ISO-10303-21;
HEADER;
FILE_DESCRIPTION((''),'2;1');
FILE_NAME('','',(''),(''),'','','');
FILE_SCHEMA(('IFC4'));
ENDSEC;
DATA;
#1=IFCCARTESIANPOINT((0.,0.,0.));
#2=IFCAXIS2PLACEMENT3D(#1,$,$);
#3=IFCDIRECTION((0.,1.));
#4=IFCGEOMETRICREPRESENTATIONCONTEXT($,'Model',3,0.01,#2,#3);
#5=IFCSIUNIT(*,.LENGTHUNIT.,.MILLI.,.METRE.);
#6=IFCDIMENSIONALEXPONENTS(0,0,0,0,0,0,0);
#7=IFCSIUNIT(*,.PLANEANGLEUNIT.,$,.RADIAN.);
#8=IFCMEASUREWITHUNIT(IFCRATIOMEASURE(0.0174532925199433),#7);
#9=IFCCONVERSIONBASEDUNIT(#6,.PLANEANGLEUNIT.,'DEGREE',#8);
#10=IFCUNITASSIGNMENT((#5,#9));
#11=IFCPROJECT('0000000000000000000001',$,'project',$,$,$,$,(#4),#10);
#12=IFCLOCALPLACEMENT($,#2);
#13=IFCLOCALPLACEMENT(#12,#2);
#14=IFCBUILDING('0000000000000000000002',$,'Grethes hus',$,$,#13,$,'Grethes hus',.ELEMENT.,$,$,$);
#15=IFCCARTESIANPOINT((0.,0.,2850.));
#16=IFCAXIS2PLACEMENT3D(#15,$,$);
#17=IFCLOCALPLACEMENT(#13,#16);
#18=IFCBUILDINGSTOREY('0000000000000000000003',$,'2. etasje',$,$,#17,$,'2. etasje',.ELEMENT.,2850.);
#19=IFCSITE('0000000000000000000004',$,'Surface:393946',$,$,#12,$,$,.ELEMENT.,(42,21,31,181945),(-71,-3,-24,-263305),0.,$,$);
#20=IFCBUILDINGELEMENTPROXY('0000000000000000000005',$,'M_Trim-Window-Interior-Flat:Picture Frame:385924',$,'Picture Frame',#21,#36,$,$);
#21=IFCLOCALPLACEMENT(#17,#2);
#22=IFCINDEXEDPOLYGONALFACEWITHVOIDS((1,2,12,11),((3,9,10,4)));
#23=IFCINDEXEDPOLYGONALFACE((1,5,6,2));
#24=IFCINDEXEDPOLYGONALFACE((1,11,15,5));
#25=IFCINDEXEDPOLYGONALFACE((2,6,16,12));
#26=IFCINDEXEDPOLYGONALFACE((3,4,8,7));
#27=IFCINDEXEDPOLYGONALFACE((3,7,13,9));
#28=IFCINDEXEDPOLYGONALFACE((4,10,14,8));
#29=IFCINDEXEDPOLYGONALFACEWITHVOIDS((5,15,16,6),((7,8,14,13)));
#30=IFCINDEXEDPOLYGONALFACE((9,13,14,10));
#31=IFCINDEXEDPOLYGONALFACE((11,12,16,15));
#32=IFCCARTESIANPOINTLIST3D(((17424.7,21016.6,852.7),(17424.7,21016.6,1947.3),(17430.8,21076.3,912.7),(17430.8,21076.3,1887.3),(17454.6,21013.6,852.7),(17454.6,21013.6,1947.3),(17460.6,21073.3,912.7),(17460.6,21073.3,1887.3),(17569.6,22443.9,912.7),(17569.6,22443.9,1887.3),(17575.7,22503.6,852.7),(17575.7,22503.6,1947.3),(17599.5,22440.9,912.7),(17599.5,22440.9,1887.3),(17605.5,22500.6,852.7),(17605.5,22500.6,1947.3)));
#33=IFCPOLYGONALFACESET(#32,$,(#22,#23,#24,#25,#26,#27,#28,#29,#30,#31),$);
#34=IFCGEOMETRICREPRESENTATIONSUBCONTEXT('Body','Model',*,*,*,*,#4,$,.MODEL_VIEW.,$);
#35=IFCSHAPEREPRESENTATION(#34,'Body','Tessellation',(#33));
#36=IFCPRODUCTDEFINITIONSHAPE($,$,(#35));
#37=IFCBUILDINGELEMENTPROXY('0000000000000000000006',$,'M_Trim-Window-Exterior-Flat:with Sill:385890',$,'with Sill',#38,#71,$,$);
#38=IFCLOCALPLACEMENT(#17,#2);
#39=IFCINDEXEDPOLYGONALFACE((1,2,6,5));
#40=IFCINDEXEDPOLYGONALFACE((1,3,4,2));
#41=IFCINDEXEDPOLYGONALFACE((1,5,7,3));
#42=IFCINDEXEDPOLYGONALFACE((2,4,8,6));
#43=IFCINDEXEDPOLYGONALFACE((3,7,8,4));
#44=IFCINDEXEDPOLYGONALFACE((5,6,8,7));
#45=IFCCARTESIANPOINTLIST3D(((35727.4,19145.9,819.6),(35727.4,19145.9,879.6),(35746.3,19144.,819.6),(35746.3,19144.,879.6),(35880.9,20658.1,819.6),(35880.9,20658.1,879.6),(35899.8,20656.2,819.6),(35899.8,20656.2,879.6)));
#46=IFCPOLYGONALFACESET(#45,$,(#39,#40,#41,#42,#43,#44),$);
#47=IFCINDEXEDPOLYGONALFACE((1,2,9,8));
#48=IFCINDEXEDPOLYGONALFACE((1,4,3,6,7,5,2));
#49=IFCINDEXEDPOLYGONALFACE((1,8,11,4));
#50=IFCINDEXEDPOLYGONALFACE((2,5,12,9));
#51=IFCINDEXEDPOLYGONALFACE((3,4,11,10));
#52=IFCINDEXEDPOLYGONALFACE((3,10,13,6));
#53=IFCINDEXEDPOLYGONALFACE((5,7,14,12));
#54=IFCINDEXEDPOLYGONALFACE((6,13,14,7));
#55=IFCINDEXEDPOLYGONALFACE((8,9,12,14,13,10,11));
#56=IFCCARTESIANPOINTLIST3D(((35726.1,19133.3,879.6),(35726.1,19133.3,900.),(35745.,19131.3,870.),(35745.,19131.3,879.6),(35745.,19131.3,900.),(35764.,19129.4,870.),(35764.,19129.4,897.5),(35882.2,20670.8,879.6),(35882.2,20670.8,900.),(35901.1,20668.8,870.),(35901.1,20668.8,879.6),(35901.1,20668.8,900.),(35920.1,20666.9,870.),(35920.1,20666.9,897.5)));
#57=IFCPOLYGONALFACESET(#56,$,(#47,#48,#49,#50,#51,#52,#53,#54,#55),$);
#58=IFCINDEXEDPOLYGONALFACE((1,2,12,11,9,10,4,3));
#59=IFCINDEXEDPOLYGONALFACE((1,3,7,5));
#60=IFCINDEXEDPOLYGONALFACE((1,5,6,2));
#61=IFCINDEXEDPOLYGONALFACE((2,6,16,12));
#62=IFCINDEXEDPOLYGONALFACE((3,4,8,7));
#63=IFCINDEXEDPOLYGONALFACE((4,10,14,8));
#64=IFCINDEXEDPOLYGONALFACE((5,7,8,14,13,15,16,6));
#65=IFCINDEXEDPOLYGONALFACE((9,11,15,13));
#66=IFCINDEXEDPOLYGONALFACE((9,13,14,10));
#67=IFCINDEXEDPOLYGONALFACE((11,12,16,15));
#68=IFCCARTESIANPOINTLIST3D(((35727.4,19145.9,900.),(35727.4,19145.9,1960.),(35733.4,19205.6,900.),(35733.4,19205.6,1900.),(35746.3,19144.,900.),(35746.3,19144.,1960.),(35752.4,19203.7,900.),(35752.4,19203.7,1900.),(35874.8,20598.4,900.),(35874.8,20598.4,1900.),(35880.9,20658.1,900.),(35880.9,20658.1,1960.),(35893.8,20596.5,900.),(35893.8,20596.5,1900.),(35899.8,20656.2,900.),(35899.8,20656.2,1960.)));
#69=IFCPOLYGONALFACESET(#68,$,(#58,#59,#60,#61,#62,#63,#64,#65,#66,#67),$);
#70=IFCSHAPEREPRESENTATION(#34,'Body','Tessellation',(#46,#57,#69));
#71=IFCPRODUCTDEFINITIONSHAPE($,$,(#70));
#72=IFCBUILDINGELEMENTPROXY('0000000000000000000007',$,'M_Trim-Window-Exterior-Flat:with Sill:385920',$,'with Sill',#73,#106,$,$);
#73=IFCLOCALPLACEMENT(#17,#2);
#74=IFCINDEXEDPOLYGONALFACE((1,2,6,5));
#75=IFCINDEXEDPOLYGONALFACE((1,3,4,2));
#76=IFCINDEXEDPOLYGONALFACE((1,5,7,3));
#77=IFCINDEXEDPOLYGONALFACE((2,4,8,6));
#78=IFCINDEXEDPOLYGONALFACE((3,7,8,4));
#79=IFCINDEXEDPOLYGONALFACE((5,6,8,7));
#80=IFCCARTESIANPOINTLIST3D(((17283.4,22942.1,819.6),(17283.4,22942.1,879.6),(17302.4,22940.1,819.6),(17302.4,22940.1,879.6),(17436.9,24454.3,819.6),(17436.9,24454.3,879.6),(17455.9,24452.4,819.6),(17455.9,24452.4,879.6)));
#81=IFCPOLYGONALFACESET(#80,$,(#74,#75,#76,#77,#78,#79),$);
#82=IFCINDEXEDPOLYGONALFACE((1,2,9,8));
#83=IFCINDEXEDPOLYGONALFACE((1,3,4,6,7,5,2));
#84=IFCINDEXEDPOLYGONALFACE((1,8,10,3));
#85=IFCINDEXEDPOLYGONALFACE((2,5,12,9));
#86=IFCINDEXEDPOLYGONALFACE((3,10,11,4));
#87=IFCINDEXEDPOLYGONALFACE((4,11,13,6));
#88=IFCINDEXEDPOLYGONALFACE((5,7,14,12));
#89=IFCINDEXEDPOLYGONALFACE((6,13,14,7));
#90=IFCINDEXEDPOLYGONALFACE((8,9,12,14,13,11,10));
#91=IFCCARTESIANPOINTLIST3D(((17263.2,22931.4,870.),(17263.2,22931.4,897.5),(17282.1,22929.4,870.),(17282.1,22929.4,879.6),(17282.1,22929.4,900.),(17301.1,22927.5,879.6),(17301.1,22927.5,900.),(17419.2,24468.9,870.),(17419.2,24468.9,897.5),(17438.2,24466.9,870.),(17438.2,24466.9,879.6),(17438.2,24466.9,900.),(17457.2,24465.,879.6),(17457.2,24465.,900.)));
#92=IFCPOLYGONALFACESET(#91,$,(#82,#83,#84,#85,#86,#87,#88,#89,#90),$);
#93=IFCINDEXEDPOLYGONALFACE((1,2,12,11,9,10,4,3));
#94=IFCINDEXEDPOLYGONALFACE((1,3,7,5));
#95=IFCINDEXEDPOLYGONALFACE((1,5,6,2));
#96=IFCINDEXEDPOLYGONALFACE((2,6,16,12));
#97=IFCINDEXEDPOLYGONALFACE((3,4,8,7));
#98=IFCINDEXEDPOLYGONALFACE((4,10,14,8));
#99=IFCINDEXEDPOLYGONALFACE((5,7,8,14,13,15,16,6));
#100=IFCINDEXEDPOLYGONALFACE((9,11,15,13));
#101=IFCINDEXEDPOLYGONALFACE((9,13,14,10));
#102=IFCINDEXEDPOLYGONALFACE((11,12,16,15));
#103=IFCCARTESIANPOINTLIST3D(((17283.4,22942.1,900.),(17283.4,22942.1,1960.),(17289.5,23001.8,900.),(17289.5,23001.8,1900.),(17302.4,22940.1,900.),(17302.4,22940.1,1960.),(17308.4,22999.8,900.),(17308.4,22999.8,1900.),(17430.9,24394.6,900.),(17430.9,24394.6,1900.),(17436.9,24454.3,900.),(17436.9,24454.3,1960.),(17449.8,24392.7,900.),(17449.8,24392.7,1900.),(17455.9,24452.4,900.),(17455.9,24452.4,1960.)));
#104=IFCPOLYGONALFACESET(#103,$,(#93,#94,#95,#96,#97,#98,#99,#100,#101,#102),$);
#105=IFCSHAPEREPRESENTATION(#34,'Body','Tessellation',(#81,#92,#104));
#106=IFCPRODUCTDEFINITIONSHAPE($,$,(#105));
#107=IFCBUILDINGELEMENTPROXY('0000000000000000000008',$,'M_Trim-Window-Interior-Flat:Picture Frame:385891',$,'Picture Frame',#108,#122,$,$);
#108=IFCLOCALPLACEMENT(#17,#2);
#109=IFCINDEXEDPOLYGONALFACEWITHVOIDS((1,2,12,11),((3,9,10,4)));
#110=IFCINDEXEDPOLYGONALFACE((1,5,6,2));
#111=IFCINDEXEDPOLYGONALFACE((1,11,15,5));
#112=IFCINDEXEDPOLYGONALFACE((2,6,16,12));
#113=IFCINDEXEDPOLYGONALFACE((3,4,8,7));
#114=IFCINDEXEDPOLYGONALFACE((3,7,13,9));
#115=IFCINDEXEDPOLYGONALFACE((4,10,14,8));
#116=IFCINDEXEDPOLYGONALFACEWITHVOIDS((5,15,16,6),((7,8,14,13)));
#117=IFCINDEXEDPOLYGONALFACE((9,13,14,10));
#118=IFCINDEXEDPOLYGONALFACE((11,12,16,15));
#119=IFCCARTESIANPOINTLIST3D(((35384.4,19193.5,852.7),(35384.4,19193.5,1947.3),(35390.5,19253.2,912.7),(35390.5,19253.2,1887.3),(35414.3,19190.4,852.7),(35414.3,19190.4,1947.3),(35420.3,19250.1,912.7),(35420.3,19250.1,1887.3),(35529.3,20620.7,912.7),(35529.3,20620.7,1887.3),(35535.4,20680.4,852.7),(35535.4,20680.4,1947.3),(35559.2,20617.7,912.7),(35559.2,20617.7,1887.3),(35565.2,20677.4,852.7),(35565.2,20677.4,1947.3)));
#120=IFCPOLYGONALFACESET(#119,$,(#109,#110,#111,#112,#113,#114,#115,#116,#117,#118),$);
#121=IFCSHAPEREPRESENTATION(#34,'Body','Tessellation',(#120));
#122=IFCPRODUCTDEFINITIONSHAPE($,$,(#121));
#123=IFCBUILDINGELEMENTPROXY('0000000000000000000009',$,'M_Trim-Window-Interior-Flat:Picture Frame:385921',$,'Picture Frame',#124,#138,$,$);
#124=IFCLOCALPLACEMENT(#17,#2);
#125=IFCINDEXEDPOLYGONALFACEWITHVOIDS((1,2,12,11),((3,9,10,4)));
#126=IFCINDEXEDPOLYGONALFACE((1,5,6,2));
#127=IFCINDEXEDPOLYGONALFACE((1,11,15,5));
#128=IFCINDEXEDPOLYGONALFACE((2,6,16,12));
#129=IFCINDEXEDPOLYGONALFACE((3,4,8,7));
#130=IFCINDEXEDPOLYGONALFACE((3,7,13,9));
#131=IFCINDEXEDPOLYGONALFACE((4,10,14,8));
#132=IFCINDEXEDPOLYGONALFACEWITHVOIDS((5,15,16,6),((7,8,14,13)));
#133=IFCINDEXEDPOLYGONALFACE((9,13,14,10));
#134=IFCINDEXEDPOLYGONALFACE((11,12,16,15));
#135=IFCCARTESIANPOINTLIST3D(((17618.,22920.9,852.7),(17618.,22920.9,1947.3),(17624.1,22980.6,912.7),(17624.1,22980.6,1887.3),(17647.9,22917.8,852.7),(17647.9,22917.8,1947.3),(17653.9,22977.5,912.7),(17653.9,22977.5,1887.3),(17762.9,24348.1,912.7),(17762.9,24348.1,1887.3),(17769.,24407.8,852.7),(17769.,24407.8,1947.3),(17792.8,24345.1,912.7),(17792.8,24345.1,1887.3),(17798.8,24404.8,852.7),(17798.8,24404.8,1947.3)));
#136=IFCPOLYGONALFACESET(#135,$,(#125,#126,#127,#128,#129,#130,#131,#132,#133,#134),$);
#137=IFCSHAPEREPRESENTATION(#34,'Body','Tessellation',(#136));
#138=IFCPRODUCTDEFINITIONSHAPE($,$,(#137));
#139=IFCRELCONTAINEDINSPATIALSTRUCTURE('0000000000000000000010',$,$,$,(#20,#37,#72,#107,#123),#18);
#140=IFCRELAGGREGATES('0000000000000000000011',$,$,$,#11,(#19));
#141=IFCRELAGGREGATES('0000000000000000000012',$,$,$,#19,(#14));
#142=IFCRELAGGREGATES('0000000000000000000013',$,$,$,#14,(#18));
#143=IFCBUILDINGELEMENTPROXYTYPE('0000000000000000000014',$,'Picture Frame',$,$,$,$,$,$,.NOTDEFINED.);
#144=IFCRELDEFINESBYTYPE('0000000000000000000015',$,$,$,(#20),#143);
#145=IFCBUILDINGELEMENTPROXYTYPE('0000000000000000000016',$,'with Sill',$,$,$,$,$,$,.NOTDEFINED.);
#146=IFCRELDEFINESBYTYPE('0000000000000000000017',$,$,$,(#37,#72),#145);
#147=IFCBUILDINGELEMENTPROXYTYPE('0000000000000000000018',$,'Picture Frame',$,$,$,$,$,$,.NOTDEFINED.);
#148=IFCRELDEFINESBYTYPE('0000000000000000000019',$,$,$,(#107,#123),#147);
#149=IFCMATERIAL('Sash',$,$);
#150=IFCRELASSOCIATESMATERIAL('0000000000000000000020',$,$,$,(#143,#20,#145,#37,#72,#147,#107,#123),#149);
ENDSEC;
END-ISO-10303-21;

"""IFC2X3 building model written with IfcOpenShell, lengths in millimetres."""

from ifc_helpers import new_model, entity, si_unit, converted_unit, direction, frame, frame_2d, origin, place, context, subcontext, project, spatial, polyline, rectangle, outline, extrude, source, transform, mapped, material, type_object, type_shapes, element, save


model = new_model("IFC2X3")

# Units and contexts
model_context = context("Model", 3, precision=0.01, world=origin(), true_north=direction((0.0, 1.0)))
body_context = subcontext(model_context, "Body", "Model", "MODEL_VIEW")
ifc_project = project(units=[si_unit("LENGTHUNIT", "METRE", prefix="MILLI"), converted_unit("PLANEANGLEUNIT", "DEGREE", entity("IfcRatioMeasure", 0.0174532925199433), si_unit("PLANEANGLEUNIT", "RADIAN"), dimensions=[0, 0, 0, 0, 0, 0, 0])], contexts=[model_context])

# Site, building, storey
site_placement = place(None, origin())
site = spatial("IfcSite", under=ifc_project, at=site_placement, Name="Surface:393946", CompositionType="ELEMENT", RefLatitude=(42, 21, 31, 181945), RefLongitude=(-71, -3, -24, -263305), RefElevation=0.0)
building_placement = place(site_placement, origin())
building = spatial("IfcBuilding", under=site, at=building_placement, Name="Grethes hus", LongName="Grethes hus", CompositionType="ELEMENT")
storey_placement = place(building_placement, frame((0.0, 0.0, 2850.0)))
storey = spatial("IfcBuildingStorey", under=building, at=storey_placement, Name="2. etasje", LongName="2. etasje", CompositionType="ELEMENT", Elevation=2850.0)

# Building element proxies
ifc_material_1 = material(Name="Sash")
building_element_proxy_type_1 = type_object("IfcBuildingElementProxyType", Name="Picture Frame", PredefinedType="NOTDEFINED", material=ifc_material_1)
shared_shape_1 = source(origin(), body_context, "Body", "SweptSolid", [
    extrude(outline(polyline([(-747.3, -547.3), (747.3, -547.3), (747.3, 547.3), (-747.3, 547.3), (-747.3, -547.3)]), holes=[polyline([(-687.3, -487.3), (-687.3, 487.3), (687.3, 487.3), (687.3, -487.3), (-687.3, -487.3)])]), frame((0.0, -500.0, 0.0), z_axis=(0.0, 0.0, 1.0), x_axis=(-1.0, 0.0, 0.0)), (0.0, 0.0, 1.0), 30.0),
])
type_shapes(building_element_proxy_type_1, [shared_shape_1])
for number, where, z_axis, x_axis, name in (
    (1, (17500.2, 21760.1, 1900.0), (0.994887, -0.100996, 0.0), (0.100996, 0.994887, 0.0), "M_Trim-Window-Interior-Flat:Picture Frame:385924"),
):
    element("IfcBuildingElementProxy", number, at=place(storey_placement, frame(where, z_axis=z_axis, x_axis=x_axis)), inside=storey, type_object=building_element_proxy_type_1, material=ifc_material_1, Name=name, ObjectType="Picture Frame", context=body_context, shape_type="MappedRepresentation", body=[
        mapped(shared_shape_1, transform((0.0, 0.0, 0.0), scale=1.0)),
    ])
building_element_proxy_type_2 = type_object("IfcBuildingElementProxyType", Name="with Sill", PredefinedType="NOTDEFINED", material=ifc_material_1)
shared_shape_2 = source(origin(), body_context, "Body", "SweptSolid", [
    extrude(rectangle(XDim=60.0, YDim=1520.0, at=frame_2d((0.0, 0.0), x_axis=(1.0, 0.0))), frame((0.0, 1050.4, 0.0), z_axis=(0.0, 0.0, 1.0), x_axis=(0.0, 1.0, 0.0)), (0.0, 0.0, 1.0), 19.1),
    extrude(outline(polyline([(-15.2, -19.0), (12.3, -19.0), (14.8, 0.0), (14.8, 19.0), (-5.7, 19.0), (-5.7, 0.0), (-15.2, 0.0), (-15.2, -19.0)])), frame((-772.7, 1014.8, 19.0), z_axis=(1.0, 0.0, 0.0), x_axis=(0.0, -1.0, 0.0)), (0.0, 0.0, 1.0), 1545.4),
    extrude(outline(polyline([(-760.0, -545.0), (760.0, -545.0), (760.0, 515.0), (700.0, 515.0), (700.0, -485.0), (-700.0, -485.0), (-700.0, 515.0), (-760.0, 515.0), (-760.0, -545.0)])), frame((0.0, 485.0, 0.0)), (0.0, 0.0, 1.0), 19.1),
])
type_shapes(building_element_proxy_type_2, [shared_shape_2])
for number, where, z_axis, x_axis, name in (
    (2, (35804.1, 19902.0, 1900.0), (0.994887, -0.100996, 0.0), (-0.100996, -0.994887, 0.0), "M_Trim-Window-Exterior-Flat:with Sill:385890"),
    (3, (17379.1, 23696.3, 1900.0), (-0.994887, 0.100996, 0.0), (0.100996, 0.994887, 0.0), "M_Trim-Window-Exterior-Flat:with Sill:385920"),
):
    element("IfcBuildingElementProxy", number, at=place(storey_placement, frame(where, z_axis=z_axis, x_axis=x_axis)), inside=storey, type_object=building_element_proxy_type_2, material=ifc_material_1, Name=name, ObjectType="with Sill", context=body_context, shape_type="MappedRepresentation", body=[
        mapped(shared_shape_2, transform((0.0, 0.0, 0.0), scale=1.0)),
    ])
building_element_proxy_type_3 = type_object("IfcBuildingElementProxyType", Name="Picture Frame", PredefinedType="NOTDEFINED", material=ifc_material_1)
shared_shape_3 = source(origin(), body_context, "Body", "SweptSolid", [
    extrude(outline(polyline([(-547.3, -747.3), (547.3, -747.3), (547.3, 747.3), (-547.3, 747.3), (-547.3, -747.3)]), holes=[polyline([(-487.3, -687.3), (-487.3, 687.3), (487.3, 687.3), (487.3, -687.3), (-487.3, -687.3)])]), frame((0.0, 500.0, 0.0), z_axis=(0.0, 0.0, 1.0), x_axis=(0.0, 1.0, 0.0)), (0.0, 0.0, 1.0), 30.0),
])
type_shapes(building_element_proxy_type_3, [shared_shape_3])
for number, where, z_axis, x_axis, name in (
    (4, (35489.7, 19933.9, 1900.0), (-0.994887, 0.100996, 0.0), (0.100996, 0.994887, 0.0), "M_Trim-Window-Interior-Flat:Picture Frame:385891"),
    (5, (17693.5, 23664.3, 1900.0), (0.994887, -0.100996, 0.0), (-0.100996, -0.994887, 0.0), "M_Trim-Window-Interior-Flat:Picture Frame:385921"),
):
    element("IfcBuildingElementProxy", number, at=place(storey_placement, frame(where, z_axis=z_axis, x_axis=x_axis)), inside=storey, type_object=building_element_proxy_type_3, material=ifc_material_1, Name=name, ObjectType="Picture Frame", context=body_context, shape_type="MappedRepresentation", body=[
        mapped(shared_shape_3, transform((0.0, 0.0, 0.0), scale=1.0)),
    ])

save(model, "model.ifc")
